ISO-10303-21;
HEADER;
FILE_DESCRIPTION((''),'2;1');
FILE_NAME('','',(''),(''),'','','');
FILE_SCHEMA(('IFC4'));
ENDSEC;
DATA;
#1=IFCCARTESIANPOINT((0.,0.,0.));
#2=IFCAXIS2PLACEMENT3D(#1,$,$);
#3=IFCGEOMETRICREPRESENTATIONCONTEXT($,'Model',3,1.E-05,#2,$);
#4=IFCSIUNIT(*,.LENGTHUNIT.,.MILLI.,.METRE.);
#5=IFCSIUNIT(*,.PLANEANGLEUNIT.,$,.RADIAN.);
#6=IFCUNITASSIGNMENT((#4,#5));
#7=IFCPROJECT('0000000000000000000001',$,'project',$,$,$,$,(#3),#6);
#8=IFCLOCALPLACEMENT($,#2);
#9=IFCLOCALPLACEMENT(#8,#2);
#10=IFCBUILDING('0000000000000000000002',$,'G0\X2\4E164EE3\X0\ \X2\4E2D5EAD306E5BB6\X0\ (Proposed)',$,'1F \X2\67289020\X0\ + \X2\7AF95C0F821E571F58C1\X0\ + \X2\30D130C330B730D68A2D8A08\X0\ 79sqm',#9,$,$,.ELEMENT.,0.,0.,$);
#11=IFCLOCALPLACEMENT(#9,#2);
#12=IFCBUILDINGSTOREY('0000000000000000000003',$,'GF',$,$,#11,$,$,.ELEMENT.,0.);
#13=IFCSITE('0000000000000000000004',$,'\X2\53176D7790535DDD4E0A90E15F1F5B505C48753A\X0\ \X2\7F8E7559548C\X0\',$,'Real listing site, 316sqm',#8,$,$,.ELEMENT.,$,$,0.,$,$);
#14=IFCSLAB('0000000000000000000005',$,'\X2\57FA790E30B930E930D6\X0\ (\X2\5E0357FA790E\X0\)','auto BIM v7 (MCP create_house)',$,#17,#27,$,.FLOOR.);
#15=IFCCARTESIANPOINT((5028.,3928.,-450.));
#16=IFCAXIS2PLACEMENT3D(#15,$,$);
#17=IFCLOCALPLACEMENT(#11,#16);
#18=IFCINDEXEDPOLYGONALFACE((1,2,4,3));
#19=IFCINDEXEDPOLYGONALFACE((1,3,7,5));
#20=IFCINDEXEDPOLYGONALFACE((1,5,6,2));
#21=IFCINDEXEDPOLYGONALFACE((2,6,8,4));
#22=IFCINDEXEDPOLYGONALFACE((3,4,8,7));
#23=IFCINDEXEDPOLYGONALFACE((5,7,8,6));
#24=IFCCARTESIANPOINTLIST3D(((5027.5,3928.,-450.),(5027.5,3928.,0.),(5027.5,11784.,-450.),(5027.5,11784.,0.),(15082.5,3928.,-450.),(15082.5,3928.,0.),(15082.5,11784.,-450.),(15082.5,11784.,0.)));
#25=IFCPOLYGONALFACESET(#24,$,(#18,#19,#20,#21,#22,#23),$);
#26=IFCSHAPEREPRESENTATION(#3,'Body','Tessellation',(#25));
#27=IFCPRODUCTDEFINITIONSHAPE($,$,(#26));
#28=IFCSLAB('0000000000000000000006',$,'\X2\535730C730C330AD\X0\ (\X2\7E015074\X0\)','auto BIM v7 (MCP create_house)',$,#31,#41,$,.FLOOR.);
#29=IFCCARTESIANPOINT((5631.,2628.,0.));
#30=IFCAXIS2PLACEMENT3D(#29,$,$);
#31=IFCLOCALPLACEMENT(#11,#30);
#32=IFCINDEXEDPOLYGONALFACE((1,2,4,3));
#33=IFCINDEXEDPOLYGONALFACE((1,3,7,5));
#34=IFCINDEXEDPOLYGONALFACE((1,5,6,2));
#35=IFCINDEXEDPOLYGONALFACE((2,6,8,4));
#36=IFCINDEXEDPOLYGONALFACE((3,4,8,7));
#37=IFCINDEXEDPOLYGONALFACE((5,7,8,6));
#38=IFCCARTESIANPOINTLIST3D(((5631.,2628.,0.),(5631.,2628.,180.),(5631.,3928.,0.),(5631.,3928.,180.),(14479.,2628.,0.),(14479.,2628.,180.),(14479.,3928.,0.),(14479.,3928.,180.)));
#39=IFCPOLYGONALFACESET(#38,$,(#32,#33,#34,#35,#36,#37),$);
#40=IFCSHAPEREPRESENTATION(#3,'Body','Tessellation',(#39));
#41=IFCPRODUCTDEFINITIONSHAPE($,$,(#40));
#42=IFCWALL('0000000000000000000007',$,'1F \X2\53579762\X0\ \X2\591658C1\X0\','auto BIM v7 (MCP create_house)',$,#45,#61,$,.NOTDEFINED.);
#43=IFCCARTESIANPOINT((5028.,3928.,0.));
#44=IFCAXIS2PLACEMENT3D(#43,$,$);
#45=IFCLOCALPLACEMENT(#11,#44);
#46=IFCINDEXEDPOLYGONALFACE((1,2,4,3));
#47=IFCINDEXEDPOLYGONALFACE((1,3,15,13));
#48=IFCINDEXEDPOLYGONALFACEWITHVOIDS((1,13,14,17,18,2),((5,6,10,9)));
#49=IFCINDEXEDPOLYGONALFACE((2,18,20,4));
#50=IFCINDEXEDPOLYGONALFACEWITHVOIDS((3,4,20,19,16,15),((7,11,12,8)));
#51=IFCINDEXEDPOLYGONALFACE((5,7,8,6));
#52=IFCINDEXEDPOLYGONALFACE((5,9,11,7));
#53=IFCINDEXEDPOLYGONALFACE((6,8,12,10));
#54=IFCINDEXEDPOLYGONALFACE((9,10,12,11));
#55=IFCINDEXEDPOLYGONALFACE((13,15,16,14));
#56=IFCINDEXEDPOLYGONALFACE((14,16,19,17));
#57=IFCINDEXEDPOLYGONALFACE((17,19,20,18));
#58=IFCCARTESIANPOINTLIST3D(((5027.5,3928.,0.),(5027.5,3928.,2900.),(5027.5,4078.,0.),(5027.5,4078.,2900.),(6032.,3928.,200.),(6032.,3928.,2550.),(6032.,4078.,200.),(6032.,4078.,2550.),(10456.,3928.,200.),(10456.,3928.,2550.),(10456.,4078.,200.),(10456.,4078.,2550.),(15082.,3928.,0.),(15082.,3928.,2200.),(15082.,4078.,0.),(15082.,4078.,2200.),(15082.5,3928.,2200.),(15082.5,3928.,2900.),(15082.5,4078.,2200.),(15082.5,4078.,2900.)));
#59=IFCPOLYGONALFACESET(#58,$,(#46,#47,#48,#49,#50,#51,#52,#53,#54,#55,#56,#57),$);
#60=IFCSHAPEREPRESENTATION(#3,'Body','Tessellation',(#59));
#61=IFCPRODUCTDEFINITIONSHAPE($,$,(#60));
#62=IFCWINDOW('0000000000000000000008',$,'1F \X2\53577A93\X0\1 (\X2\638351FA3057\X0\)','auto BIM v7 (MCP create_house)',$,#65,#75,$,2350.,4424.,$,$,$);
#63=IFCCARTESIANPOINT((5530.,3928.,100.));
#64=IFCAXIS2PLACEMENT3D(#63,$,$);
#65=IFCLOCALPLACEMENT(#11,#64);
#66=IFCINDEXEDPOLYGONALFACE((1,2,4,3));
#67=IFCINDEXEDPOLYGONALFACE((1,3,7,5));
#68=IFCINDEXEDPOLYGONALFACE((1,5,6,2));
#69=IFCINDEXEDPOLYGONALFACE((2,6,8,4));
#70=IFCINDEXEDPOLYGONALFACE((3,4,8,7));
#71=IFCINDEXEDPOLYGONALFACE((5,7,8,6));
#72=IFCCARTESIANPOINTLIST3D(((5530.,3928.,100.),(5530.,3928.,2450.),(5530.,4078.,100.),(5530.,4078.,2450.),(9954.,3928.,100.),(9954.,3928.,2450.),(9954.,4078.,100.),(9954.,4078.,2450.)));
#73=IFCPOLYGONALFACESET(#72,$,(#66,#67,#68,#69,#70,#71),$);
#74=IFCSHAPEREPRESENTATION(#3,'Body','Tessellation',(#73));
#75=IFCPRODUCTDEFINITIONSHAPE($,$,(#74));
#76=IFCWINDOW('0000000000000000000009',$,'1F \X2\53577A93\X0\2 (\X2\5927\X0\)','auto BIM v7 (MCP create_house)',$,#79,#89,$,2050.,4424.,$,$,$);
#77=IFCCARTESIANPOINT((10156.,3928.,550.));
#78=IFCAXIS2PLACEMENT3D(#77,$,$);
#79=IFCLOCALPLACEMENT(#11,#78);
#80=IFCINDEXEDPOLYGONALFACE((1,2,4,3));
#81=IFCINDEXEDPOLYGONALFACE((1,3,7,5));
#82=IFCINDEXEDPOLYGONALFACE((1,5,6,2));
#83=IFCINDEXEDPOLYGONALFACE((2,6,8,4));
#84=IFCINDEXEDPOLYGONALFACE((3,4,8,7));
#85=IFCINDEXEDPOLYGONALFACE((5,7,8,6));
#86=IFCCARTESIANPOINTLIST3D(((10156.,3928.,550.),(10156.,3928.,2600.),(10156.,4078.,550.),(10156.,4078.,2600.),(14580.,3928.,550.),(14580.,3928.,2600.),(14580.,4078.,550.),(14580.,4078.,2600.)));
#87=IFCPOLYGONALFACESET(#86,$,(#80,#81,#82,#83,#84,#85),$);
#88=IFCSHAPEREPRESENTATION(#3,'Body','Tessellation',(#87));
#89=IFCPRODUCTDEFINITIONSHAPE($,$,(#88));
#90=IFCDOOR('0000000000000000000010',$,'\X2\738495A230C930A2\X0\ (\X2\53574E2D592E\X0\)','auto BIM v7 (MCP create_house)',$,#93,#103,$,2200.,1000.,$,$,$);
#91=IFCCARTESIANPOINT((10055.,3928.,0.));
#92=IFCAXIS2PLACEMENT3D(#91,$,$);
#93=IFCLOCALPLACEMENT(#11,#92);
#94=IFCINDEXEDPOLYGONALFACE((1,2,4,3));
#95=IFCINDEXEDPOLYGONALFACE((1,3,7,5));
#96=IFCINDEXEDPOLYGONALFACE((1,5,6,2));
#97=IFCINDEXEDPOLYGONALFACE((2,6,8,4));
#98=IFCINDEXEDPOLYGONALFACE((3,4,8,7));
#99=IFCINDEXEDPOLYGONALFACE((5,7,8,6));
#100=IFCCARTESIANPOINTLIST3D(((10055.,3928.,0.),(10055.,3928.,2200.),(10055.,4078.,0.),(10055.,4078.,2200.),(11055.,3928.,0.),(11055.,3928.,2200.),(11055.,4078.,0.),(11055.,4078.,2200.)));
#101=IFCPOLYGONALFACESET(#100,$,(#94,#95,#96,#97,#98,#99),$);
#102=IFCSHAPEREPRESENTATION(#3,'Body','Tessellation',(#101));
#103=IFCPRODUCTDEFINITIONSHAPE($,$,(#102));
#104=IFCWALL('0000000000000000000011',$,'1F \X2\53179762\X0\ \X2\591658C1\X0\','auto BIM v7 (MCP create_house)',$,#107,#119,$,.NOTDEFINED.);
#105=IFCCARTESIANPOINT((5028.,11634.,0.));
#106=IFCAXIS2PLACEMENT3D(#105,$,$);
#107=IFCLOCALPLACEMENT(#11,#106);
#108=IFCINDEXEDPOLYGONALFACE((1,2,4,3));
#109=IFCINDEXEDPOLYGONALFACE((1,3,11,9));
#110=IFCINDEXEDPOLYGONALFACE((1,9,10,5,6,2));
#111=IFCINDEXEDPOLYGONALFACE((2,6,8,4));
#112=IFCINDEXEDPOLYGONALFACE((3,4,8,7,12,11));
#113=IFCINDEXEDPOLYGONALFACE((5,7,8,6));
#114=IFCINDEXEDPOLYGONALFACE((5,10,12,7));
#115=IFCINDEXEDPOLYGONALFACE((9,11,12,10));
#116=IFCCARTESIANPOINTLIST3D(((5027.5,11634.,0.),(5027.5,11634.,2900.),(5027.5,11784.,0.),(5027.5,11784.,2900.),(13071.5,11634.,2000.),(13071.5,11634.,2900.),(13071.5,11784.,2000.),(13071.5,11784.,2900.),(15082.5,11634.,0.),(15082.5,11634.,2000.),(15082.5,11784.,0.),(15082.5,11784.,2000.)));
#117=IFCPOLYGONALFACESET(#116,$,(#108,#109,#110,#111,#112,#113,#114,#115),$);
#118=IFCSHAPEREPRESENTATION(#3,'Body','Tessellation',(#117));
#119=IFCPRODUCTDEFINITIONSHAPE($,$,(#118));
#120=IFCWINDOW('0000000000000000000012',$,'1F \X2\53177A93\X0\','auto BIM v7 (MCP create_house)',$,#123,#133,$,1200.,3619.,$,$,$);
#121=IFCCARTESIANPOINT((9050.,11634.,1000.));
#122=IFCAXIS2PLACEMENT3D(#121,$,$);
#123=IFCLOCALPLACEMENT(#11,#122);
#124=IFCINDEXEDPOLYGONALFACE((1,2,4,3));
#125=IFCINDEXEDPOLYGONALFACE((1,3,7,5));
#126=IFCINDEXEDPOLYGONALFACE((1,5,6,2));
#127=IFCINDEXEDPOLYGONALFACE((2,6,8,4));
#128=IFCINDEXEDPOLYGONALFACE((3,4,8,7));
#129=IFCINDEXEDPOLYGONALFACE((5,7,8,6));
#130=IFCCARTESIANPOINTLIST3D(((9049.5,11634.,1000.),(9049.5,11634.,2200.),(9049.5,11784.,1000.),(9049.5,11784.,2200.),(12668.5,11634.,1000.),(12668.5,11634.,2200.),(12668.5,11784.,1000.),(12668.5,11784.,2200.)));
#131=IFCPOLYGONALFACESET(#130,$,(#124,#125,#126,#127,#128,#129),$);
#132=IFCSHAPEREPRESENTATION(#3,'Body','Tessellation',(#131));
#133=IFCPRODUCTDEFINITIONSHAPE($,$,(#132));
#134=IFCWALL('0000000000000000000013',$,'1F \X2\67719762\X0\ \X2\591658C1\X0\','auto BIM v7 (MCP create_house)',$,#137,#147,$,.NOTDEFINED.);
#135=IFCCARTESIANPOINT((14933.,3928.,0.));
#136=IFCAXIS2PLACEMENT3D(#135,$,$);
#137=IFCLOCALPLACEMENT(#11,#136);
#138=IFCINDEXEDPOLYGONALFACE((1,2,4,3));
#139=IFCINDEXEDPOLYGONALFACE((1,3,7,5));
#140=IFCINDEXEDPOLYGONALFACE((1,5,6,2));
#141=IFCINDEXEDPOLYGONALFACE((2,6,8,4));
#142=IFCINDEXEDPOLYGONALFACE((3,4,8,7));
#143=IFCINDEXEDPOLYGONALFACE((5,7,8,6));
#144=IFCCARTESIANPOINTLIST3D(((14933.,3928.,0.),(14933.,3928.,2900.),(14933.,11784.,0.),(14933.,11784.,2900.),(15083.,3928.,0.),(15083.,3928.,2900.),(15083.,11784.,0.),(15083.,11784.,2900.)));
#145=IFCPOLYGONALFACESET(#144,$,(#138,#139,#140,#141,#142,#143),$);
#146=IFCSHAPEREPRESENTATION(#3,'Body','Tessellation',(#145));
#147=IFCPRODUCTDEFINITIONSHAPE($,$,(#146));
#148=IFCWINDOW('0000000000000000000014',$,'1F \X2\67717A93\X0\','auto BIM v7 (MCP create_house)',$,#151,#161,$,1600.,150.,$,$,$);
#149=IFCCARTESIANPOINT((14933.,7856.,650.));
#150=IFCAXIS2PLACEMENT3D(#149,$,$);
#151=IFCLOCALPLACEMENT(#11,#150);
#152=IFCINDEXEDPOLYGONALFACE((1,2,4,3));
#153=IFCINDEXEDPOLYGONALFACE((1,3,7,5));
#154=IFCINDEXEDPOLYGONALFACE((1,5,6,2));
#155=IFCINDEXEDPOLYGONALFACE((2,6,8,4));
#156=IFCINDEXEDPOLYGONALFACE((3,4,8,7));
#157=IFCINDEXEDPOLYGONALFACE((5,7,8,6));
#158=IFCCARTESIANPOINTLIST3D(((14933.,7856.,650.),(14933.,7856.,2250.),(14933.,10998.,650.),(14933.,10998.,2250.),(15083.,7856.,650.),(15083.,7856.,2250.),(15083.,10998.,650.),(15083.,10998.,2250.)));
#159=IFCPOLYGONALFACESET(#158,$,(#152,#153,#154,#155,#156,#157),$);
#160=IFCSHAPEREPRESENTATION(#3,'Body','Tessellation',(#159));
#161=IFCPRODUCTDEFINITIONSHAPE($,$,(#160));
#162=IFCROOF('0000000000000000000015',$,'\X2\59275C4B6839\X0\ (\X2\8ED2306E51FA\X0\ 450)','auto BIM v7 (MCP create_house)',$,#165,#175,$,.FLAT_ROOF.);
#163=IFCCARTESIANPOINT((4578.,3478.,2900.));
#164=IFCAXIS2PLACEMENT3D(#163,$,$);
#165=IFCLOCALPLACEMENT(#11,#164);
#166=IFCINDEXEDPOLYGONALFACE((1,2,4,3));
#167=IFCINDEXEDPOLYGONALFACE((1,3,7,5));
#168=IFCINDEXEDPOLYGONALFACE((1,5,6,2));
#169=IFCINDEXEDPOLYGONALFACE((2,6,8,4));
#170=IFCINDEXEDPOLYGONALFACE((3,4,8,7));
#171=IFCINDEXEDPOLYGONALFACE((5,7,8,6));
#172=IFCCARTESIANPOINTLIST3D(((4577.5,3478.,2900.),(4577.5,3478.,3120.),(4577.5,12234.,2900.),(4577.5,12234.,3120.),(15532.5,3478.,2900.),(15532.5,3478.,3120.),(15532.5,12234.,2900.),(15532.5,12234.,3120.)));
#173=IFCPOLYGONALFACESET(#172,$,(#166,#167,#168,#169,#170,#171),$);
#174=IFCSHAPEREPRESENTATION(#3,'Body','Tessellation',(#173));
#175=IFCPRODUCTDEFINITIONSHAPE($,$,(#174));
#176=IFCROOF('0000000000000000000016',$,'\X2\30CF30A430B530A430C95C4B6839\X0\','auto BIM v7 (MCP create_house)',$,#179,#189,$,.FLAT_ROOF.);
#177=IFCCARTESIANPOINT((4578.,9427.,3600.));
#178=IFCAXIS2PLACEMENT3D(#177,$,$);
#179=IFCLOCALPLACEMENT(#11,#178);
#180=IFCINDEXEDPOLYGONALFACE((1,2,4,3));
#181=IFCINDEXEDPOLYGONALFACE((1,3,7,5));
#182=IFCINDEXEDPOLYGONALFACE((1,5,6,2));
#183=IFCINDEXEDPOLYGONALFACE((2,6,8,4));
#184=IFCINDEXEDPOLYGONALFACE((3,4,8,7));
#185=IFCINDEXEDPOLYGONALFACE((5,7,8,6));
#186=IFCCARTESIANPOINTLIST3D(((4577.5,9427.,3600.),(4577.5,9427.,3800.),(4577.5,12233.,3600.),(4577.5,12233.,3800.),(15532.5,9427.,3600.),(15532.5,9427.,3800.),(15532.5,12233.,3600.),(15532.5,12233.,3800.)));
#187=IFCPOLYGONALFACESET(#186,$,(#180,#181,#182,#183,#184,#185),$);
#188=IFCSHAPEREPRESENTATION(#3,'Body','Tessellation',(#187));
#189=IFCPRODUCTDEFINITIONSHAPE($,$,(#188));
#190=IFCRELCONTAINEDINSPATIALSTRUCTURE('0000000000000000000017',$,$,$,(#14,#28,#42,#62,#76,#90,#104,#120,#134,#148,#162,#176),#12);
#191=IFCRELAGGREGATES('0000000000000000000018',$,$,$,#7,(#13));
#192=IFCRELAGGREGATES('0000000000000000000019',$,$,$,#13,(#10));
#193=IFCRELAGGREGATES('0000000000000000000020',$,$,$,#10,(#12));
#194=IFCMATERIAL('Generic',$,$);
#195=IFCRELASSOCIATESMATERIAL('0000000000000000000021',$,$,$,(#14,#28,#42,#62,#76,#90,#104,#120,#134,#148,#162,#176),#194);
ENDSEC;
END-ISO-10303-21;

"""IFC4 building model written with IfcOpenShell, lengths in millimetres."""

from ifc_helpers import new_model, si_unit, frame, frame_2d, origin, place, context, project, spatial, rectangle, extrude, material, element, fill, save


model = new_model("IFC4")

# Units and contexts
model_context = context("Model", 3, precision=1e-05, world=origin())
ifc_project = project(units=[si_unit("LENGTHUNIT", "METRE", prefix="MILLI"), si_unit("PLANEANGLEUNIT", "RADIAN")], contexts=[model_context])

# Site, building, storey
site_placement = place(None, origin())
site = spatial("IfcSite", under=ifc_project, at=site_placement, Name="北海道川上郡弟子屈町 美留和", ObjectType="Real listing site, 316sqm", CompositionType="ELEMENT", RefElevation=0.0)
building_placement = place(site_placement, origin())
building = spatial("IfcBuilding", under=site, at=building_placement, Name="G0世代 中庭の家 (Proposed)", ObjectType="1F 木造 + 竹小舞土壁 + パッシブ設計 79sqm", CompositionType="ELEMENT", ElevationOfRefHeight=0.0, ElevationOfTerrain=0.0)
storey_placement = place(building_placement, origin())
storey = spatial("IfcBuildingStorey", under=building, at=storey_placement, Name="GF", CompositionType="ELEMENT", Elevation=0.0)

# Slabs
ifc_material = material(Name="Generic")
slab_1_placement = place(storey_placement, frame((5028.0, 3928.0, -450.0)))
element("IfcSlab", 1, at=slab_1_placement, inside=storey, material=ifc_material, Name="基礎スラブ (布基礎)", Description="auto BIM v7 (MCP create_house)", PredefinedType="FLOOR", context=model_context, shape_type="SweptSolid", body=[
    extrude(rectangle(XDim=10055.0, YDim=7856.0, at=frame_2d((5027.0, 3928.0))), frame((5028.0, 3928.0, -450.0)), (0.0, 0.0, 1.0), 450.0),
])
slab_2_placement = place(storey_placement, frame((5631.0, 2628.0, 0.0)))
element("IfcSlab", 2, at=slab_2_placement, inside=storey, material=ifc_material, Name="南デッキ (縁側)", Description="auto BIM v7 (MCP create_house)", PredefinedType="FLOOR", context=model_context, shape_type="SweptSolid", body=[
    extrude(rectangle(XDim=8848.0, YDim=1300.0, at=frame_2d((4424.0, 650.0))), frame((5631.0, 2628.0, 0.0)), (0.0, 0.0, 1.0), 180.0),
])

# Wall, openings, windows, door
wall_1_placement = place(storey_placement, frame((5028.0, 3928.0, 0.0)))
wall_1 = element("IfcWall", 3, at=wall_1_placement, inside=storey, material=ifc_material, Name="1F 南面 外壁", Description="auto BIM v7 (MCP create_house)", PredefinedType="NOTDEFINED", context=model_context, shape_type="SweptSolid", body=[
    extrude(rectangle(XDim=10055.0, YDim=150.0, at=frame_2d((5027.0, 75.0))), frame((5028.0, 3928.0, 0.0)), (0.0, 0.0, 1.0), 2900.0),
])
opening_1_placement = place(storey_placement, frame((5530.0, 3928.0, 100.0)))
opening_1 = element("IfcOpeningElement", 4, at=opening_1_placement, cuts=wall_1, PredefinedType="NOTDEFINED", context=model_context, shape_type="SweptSolid", body=[
    extrude(rectangle(XDim=4424.0, YDim=150.0, at=frame_2d((2212.0, 75.0))), frame((5530.0, 3928.0, 100.0)), (0.0, 0.0, 1.0), 2350.0),
])
opening_2_placement = place(storey_placement, frame((10156.0, 3928.0, 550.0)))
opening_2 = element("IfcOpeningElement", 5, at=opening_2_placement, cuts=wall_1, PredefinedType="NOTDEFINED", context=model_context, shape_type="SweptSolid", body=[
    extrude(rectangle(XDim=4424.0, YDim=150.0, at=frame_2d((2212.0, 75.0))), frame((10156.0, 3928.0, 550.0)), (0.0, 0.0, 1.0), 2050.0),
])
opening_3_placement = place(storey_placement, frame((10055.0, 3928.0, 0.0)))
opening_3 = element("IfcOpeningElement", 6, at=opening_3_placement, cuts=wall_1, PredefinedType="NOTDEFINED", context=model_context, shape_type="SweptSolid", body=[
    extrude(rectangle(XDim=1000.0, YDim=150.0, at=frame_2d((500.0, 75.0))), frame((10055.0, 3928.0, 0.0)), (0.0, 0.0, 1.0), 2200.0),
])
window_1_placement = place(storey_placement, frame((5530.0, 3928.0, 100.0)))
window_1 = element("IfcWindow", 7, at=window_1_placement, inside=storey, material=ifc_material, Name="1F 南窓1 (掃出し)", Description="auto BIM v7 (MCP create_house)", OverallHeight=2350.0, OverallWidth=4424.0, context=model_context, shape_type="SweptSolid", body=[
    extrude(rectangle(XDim=4424.0, YDim=150.0, at=frame_2d((2212.0, 75.0))), frame((5530.0, 3928.0, 100.0)), (0.0, 0.0, 1.0), 2350.0),
])
fill(opening_1, window_1)
window_2_placement = place(storey_placement, frame((10156.0, 3928.0, 550.0)))
window_2 = element("IfcWindow", 8, at=window_2_placement, inside=storey, material=ifc_material, Name="1F 南窓2 (大)", Description="auto BIM v7 (MCP create_house)", OverallHeight=2050.0, OverallWidth=4424.0, context=model_context, shape_type="SweptSolid", body=[
    extrude(rectangle(XDim=4424.0, YDim=150.0, at=frame_2d((2212.0, 75.0))), frame((10156.0, 3928.0, 550.0)), (0.0, 0.0, 1.0), 2050.0),
])
fill(opening_2, window_2)
door_placement = place(storey_placement, frame((10055.0, 3928.0, 0.0)))
door = element("IfcDoor", 9, at=door_placement, inside=storey, material=ifc_material, Name="玄関ドア (南中央)", Description="auto BIM v7 (MCP create_house)", OverallHeight=2200.0, OverallWidth=1000.0, context=model_context, shape_type="SweptSolid", body=[
    extrude(rectangle(XDim=1000.0, YDim=150.0, at=frame_2d((500.0, 75.0))), frame((10055.0, 3928.0, 0.0)), (0.0, 0.0, 1.0), 2200.0),
])
fill(opening_3, door)

# Walls, openings, windows
wall_2_placement = place(storey_placement, frame((5028.0, 11634.0, 0.0)))
wall_2 = element("IfcWall", 10, at=wall_2_placement, inside=storey, material=ifc_material, Name="1F 北面 外壁", Description="auto BIM v7 (MCP create_house)", PredefinedType="NOTDEFINED", context=model_context, shape_type="SweptSolid", body=[
    extrude(rectangle(XDim=10055.0, YDim=150.0, at=frame_2d((5027.0, 75.0))), frame((5028.0, 11634.0, 0.0)), (0.0, 0.0, 1.0), 2900.0),
])
opening_4_placement = place(storey_placement, frame((9050.0, 11634.0, 1000.0)))
opening_4 = element("IfcOpeningElement", 11, at=opening_4_placement, cuts=wall_2, PredefinedType="NOTDEFINED", context=model_context, shape_type="SweptSolid", body=[
    extrude(rectangle(XDim=3619.0, YDim=150.0, at=frame_2d((1809.0, 75.0))), frame((9050.0, 11634.0, 1000.0)), (0.0, 0.0, 1.0), 1200.0),
])
window_3_placement = place(storey_placement, frame((9050.0, 11634.0, 1000.0)))
window_3 = element("IfcWindow", 12, at=window_3_placement, inside=storey, material=ifc_material, Name="1F 北窓", Description="auto BIM v7 (MCP create_house)", OverallHeight=1200.0, OverallWidth=3619.0, context=model_context, shape_type="SweptSolid", body=[
    extrude(rectangle(XDim=3619.0, YDim=150.0, at=frame_2d((1809.0, 75.0))), frame((9050.0, 11634.0, 1000.0)), (0.0, 0.0, 1.0), 1200.0),
])
fill(opening_4, window_3)
wall_3_placement = place(storey_placement, frame((14933.0, 3928.0, 0.0)))
wall_3 = element("IfcWall", 13, at=wall_3_placement, inside=storey, material=ifc_material, Name="1F 東面 外壁", Description="auto BIM v7 (MCP create_house)", PredefinedType="NOTDEFINED", context=model_context, shape_type="SweptSolid", body=[
    extrude(rectangle(XDim=150.0, YDim=7856.0, at=frame_2d((75.0, 3928.0))), frame((14933.0, 3928.0, 0.0)), (0.0, 0.0, 1.0), 2900.0),
])
opening_5_placement = place(storey_placement, frame((14933.0, 7856.0, 650.0)))
opening_5 = element("IfcOpeningElement", 14, at=opening_5_placement, cuts=wall_3, PredefinedType="NOTDEFINED", context=model_context, shape_type="SweptSolid", body=[
    extrude(rectangle(XDim=150.0, YDim=3142.0, at=frame_2d((75.0, 1571.0))), frame((14933.0, 7856.0, 650.0)), (0.0, 0.0, 1.0), 1600.0),
])
window_4_placement = place(storey_placement, frame((14933.0, 7856.0, 650.0)))
window_4 = element("IfcWindow", 15, at=window_4_placement, inside=storey, material=ifc_material, Name="1F 東窓", Description="auto BIM v7 (MCP create_house)", OverallHeight=1600.0, OverallWidth=150.0, context=model_context, shape_type="SweptSolid", body=[
    extrude(rectangle(XDim=150.0, YDim=3142.0, at=frame_2d((75.0, 1571.0))), frame((14933.0, 7856.0, 650.0)), (0.0, 0.0, 1.0), 1600.0),
])
fill(opening_5, window_4)

# Roofs
roof_1_placement = place(storey_placement, frame((4578.0, 3478.0, 2900.0)))
element("IfcRoof", 16, at=roof_1_placement, inside=storey, material=ifc_material, Name="大屋根 (軒の出 450)", Description="auto BIM v7 (MCP create_house)", PredefinedType="FLAT_ROOF", context=model_context, shape_type="SweptSolid", body=[
    extrude(rectangle(XDim=10955.0, YDim=8756.0, at=frame_2d((5477.0, 4378.0))), frame((4578.0, 3478.0, 2900.0)), (0.0, 0.0, 1.0), 220.0),
])
roof_2_placement = place(storey_placement, frame((4578.0, 9427.0, 3600.0)))
element("IfcRoof", 17, at=roof_2_placement, inside=storey, material=ifc_material, Name="ハイサイド屋根", Description="auto BIM v7 (MCP create_house)", PredefinedType="FLAT_ROOF", context=model_context, shape_type="SweptSolid", body=[
    extrude(rectangle(XDim=10955.0, YDim=2806.0, at=frame_2d((5477.0, 1403.0))), frame((4578.0, 9427.0, 3600.0)), (0.0, 0.0, 1.0), 200.0),
])

save(model, "model.ifc")
